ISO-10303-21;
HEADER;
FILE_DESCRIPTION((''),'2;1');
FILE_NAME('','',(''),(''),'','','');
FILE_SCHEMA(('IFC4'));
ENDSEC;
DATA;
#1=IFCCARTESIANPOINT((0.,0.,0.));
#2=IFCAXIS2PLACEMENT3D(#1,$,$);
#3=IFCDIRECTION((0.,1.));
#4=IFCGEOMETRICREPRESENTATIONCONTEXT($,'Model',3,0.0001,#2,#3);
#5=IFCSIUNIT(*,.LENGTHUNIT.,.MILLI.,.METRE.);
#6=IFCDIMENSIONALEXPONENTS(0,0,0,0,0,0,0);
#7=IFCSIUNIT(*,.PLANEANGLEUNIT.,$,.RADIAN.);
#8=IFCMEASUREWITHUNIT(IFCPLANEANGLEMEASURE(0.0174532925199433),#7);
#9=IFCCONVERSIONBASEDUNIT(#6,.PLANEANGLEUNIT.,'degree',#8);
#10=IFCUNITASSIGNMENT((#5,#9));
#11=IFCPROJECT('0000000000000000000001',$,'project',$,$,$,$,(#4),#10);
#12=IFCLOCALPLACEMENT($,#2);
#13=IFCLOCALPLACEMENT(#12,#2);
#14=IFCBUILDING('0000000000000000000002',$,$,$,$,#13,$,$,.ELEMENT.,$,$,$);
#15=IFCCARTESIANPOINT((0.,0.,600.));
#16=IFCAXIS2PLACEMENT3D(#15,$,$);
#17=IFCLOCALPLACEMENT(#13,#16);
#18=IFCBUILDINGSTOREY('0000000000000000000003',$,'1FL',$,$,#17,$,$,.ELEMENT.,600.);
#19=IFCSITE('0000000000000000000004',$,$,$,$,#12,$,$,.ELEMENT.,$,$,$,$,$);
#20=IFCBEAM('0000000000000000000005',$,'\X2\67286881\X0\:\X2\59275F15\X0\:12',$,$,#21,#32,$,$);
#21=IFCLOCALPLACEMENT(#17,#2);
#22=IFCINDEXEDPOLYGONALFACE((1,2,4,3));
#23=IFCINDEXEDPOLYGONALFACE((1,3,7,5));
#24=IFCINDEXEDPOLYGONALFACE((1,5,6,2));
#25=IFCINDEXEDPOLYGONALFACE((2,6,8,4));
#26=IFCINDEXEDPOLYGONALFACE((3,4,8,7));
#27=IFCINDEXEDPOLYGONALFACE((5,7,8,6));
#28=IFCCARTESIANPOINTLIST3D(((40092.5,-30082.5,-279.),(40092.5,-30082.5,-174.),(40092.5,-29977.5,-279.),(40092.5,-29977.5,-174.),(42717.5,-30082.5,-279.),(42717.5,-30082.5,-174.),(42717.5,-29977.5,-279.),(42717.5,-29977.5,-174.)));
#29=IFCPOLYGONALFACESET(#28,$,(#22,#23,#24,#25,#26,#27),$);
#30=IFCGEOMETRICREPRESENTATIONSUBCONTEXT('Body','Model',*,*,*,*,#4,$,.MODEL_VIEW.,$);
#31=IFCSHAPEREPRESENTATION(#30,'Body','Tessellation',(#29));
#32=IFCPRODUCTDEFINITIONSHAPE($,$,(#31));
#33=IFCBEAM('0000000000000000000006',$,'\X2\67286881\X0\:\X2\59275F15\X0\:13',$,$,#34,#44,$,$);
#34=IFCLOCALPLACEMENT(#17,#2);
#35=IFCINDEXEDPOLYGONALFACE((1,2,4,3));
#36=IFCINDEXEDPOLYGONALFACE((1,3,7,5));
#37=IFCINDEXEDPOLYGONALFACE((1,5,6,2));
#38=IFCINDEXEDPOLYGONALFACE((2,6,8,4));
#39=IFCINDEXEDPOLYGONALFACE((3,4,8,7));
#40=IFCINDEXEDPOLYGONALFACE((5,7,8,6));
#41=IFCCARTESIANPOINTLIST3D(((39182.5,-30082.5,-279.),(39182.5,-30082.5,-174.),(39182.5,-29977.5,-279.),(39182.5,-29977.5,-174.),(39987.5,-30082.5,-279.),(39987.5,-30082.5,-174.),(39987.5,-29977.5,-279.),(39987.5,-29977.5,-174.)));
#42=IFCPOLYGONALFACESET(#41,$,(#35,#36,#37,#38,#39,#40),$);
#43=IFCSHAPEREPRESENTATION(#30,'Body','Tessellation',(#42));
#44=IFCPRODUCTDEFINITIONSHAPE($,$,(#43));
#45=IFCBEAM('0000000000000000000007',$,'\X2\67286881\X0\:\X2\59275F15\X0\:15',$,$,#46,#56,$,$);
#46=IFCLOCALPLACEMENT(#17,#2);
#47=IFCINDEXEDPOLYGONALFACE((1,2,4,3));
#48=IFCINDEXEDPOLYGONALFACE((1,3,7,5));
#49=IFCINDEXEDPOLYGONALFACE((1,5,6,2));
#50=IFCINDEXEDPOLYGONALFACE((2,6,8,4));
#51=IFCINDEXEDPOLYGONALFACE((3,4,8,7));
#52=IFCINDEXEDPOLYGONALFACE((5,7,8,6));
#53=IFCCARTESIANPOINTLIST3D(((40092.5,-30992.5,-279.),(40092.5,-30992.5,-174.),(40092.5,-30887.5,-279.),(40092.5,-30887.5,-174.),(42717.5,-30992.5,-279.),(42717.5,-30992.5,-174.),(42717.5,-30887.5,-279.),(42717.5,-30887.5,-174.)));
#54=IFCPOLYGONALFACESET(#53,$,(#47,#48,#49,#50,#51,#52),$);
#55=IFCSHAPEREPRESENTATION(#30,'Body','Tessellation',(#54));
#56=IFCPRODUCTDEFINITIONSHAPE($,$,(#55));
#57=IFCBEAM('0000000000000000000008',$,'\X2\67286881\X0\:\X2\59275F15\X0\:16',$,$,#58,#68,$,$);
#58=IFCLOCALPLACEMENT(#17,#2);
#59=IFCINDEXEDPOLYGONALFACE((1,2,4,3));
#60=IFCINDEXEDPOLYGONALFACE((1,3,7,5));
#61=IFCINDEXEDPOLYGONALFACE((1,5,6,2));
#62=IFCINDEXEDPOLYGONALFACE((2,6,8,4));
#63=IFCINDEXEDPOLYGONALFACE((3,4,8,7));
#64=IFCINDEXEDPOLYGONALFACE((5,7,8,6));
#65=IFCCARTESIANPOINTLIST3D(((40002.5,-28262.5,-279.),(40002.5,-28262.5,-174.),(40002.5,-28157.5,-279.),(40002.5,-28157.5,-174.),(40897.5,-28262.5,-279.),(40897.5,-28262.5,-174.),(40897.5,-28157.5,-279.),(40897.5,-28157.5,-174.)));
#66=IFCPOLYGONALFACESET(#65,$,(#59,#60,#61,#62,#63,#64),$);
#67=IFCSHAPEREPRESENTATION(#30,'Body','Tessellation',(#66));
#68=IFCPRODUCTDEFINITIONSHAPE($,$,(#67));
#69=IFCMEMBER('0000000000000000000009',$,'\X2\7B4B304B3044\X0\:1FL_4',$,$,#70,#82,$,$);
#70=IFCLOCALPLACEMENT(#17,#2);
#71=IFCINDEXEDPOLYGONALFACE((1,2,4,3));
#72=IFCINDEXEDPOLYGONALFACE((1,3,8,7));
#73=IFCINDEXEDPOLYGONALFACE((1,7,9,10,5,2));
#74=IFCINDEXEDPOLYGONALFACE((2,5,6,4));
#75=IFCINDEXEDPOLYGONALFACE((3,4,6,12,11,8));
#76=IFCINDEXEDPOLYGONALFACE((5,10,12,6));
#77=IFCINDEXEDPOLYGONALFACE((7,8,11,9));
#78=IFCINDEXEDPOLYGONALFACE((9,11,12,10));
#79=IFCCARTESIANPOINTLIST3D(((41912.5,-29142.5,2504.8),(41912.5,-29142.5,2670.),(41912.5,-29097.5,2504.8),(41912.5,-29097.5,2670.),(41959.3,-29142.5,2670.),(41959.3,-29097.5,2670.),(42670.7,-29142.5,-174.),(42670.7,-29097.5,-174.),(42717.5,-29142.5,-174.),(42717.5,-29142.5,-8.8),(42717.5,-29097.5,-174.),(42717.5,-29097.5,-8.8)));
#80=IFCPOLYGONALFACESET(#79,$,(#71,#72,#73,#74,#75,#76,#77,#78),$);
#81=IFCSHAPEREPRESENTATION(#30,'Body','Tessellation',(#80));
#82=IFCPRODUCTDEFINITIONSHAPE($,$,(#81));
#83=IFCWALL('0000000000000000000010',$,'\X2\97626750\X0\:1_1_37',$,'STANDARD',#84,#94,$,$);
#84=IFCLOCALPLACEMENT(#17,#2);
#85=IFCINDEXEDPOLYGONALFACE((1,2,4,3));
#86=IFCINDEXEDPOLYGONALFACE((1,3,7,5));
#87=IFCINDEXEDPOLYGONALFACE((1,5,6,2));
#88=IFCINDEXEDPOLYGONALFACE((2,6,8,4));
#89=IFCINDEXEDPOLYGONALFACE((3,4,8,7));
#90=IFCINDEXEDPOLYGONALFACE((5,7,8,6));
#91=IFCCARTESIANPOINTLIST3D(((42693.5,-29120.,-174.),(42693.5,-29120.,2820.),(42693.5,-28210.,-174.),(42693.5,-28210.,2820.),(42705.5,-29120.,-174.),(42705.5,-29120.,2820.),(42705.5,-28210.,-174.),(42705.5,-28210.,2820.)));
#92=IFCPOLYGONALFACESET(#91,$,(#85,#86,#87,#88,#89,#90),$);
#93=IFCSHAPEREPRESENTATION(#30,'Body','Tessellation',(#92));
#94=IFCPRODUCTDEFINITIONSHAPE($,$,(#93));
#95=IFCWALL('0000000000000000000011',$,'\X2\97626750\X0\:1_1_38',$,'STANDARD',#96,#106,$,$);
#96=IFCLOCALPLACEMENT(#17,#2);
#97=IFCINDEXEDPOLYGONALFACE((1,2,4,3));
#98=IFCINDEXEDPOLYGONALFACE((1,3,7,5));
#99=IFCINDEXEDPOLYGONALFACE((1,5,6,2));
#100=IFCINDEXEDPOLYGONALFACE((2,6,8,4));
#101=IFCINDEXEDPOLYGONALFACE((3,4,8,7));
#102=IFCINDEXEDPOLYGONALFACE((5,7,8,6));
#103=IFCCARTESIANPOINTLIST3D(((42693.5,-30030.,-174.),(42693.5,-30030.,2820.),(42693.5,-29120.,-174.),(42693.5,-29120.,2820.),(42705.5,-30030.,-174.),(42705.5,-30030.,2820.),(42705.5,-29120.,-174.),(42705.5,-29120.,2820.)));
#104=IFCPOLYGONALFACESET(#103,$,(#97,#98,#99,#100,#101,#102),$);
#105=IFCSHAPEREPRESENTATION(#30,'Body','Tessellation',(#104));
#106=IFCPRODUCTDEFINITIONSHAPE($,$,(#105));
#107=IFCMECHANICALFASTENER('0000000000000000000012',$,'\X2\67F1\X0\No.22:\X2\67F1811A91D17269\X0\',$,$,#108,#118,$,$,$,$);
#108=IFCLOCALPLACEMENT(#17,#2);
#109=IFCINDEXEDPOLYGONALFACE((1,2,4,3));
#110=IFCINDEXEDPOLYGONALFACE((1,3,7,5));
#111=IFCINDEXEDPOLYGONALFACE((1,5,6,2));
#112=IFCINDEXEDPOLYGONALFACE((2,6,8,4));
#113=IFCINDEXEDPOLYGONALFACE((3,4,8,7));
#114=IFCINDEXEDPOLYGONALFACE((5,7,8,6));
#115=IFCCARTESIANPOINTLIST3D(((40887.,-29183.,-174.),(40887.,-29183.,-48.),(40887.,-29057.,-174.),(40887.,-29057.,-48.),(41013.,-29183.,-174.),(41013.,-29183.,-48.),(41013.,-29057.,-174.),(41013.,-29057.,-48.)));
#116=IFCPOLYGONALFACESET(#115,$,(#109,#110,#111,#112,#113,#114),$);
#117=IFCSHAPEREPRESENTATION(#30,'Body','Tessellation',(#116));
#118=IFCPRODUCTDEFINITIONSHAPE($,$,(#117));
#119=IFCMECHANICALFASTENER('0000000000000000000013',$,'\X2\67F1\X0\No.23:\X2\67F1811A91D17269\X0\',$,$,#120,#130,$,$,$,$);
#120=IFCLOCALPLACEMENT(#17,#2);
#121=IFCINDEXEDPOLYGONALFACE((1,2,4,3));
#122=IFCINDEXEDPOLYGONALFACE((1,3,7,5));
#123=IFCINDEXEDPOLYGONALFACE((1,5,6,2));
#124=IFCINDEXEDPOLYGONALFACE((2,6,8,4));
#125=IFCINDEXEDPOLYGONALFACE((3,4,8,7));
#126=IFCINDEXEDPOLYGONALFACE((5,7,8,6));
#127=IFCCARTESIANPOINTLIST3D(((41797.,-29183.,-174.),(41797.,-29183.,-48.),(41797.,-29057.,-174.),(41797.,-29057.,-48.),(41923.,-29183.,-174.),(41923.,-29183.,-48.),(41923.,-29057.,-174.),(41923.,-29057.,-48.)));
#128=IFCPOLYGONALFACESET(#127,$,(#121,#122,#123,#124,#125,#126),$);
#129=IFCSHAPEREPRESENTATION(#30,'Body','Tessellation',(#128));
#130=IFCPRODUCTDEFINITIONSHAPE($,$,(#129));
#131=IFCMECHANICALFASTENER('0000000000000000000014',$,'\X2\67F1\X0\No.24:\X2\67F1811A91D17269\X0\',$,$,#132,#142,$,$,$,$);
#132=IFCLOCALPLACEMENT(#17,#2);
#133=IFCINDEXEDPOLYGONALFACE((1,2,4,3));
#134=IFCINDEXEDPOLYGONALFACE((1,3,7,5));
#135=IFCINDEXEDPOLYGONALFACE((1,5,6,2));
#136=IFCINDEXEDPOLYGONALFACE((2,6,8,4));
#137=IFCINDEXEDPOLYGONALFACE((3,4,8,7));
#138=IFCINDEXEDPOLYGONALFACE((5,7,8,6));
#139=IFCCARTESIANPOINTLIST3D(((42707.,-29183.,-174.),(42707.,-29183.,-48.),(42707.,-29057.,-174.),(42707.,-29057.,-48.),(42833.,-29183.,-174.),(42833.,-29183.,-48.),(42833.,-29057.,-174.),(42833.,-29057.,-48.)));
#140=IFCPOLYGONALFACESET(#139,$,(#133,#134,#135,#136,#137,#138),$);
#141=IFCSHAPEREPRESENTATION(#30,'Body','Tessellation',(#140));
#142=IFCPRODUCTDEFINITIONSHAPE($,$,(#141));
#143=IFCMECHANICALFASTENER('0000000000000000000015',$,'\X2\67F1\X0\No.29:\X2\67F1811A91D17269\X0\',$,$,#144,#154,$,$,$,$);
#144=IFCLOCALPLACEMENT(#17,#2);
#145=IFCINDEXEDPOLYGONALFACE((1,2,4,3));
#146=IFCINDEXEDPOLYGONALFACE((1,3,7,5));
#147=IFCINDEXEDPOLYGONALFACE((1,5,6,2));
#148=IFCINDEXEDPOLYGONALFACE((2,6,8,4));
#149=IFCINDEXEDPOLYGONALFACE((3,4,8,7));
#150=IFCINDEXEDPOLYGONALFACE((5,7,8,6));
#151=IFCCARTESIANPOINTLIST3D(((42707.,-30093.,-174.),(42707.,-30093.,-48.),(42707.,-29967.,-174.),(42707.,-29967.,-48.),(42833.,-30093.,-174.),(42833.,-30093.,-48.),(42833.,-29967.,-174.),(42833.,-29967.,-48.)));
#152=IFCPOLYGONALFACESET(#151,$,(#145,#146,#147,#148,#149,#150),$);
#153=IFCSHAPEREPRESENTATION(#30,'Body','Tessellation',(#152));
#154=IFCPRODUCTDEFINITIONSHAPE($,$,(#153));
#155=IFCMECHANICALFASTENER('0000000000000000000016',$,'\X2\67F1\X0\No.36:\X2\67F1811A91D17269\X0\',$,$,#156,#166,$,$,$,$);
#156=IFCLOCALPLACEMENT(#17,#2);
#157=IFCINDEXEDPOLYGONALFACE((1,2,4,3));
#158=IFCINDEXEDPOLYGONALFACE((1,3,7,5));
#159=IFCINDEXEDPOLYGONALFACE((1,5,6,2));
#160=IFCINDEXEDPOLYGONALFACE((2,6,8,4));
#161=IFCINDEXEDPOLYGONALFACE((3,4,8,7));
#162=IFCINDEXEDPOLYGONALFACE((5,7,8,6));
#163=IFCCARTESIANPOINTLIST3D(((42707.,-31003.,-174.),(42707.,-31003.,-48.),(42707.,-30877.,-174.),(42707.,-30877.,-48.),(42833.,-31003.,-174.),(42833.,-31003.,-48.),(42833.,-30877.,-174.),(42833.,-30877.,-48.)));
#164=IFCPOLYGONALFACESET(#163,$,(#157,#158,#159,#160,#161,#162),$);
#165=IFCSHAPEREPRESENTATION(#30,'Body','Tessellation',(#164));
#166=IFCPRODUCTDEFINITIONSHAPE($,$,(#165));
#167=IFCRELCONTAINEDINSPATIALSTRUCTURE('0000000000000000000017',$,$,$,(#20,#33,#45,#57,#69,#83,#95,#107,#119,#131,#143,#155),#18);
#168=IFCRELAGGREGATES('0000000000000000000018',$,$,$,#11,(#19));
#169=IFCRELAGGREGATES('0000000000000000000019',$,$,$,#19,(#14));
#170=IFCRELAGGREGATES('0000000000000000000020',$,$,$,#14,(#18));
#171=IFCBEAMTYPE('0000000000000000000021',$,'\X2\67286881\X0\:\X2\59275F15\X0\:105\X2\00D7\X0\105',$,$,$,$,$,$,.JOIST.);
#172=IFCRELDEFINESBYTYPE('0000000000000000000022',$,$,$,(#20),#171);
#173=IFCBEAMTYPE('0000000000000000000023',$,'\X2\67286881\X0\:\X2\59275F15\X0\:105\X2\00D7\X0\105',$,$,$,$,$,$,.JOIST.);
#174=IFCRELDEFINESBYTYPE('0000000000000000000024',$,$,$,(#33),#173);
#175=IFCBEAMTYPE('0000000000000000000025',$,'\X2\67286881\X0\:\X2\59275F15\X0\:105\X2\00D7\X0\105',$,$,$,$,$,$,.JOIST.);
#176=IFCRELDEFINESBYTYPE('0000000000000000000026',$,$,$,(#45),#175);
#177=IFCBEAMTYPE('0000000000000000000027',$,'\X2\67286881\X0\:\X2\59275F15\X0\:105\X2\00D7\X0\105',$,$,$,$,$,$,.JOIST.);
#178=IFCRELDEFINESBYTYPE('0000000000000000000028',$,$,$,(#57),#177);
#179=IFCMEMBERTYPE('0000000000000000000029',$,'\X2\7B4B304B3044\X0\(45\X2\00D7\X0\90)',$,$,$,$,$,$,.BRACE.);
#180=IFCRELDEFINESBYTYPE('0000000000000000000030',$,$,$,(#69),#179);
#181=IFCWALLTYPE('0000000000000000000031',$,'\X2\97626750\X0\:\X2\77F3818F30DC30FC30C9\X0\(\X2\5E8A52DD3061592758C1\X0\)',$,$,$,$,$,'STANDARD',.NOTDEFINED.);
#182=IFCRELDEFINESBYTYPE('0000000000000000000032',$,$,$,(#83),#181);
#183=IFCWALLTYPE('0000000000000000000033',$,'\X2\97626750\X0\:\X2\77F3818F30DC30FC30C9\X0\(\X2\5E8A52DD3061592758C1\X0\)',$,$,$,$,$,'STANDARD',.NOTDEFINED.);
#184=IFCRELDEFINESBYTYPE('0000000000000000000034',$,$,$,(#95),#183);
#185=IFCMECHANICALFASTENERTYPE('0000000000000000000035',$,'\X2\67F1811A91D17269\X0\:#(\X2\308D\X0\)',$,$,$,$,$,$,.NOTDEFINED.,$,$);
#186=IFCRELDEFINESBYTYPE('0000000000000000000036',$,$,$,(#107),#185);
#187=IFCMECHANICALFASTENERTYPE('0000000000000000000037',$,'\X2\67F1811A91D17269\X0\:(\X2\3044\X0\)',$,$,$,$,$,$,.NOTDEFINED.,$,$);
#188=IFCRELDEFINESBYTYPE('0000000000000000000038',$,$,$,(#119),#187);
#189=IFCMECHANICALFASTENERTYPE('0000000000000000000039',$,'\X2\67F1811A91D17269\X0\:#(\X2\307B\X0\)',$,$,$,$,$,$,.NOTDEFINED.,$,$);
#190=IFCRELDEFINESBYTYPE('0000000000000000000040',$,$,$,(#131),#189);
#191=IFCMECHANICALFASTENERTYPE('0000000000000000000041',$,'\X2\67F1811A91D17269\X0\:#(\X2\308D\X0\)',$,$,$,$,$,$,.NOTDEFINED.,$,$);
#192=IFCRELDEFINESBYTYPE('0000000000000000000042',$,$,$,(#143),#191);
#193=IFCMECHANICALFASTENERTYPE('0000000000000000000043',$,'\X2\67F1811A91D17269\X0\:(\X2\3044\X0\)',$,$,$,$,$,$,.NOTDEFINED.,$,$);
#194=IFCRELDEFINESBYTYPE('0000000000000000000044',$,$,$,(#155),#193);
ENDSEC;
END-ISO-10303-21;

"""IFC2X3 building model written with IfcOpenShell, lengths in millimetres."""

from ifc_helpers import new_model, entity, si_unit, converted_unit, direction, frame, origin, origin_with_axes, origin_2d, place, context, subcontext, project, spatial, polyline, rectangle, outline, extrude, type_object, element, save


model = new_model("IFC2X3")

# Units and contexts
model_context = context("Model", 3, precision=0.0001, world=origin(), true_north=direction((0.0, 1.0)))
body_context = subcontext(model_context, "Body", "Model", "MODEL_VIEW")
ifc_project = project(units=[si_unit("LENGTHUNIT", "METRE", prefix="MILLI"), converted_unit("PLANEANGLEUNIT", "degree", entity("IfcPlaneAngleMeasure", 0.0174532925199433), si_unit("PLANEANGLEUNIT", "RADIAN"), dimensions=[0, 0, 0, 0, 0, 0, 0])], contexts=[model_context])

# Site, building, storey
site_placement = place(None, origin())
site = spatial("IfcSite", under=ifc_project, at=site_placement, CompositionType="ELEMENT")
building_placement = place(site_placement, origin())
building = spatial("IfcBuilding", under=site, at=building_placement, CompositionType="ELEMENT")
storey_placement = place(building_placement, frame((0.0, 0.0, 600.0)))
storey = spatial("IfcBuildingStorey", under=building, at=storey_placement, Name="1FL", CompositionType="ELEMENT", Elevation=600.0)

# Beams
beam_type_1 = type_object("IfcBeamType", Name="木梁:大引:105×105", PredefinedType="JOIST")
beam_1_placement = place(storey_placement, frame((40092.5, -30030.0, -226.5), z_axis=(1.0, 0.0, 0.0), x_axis=(0.0, 1.0, 0.0)))
element("IfcBeam", 1, at=beam_1_placement, inside=storey, type_object=beam_type_1, Name="木梁:大引:12", context=body_context, shape_type="SweptSolid", body=[
    extrude(rectangle(XDim=105.0, YDim=105.0, at=origin_2d()), origin_with_axes(), (0.0, 0.0, 1.0), 2625.0),
])
beam_type_2 = type_object("IfcBeamType", Name="木梁:大引:105×105", PredefinedType="JOIST")
beam_2_placement = place(storey_placement, frame((39182.5, -30030.0, -226.5), z_axis=(1.0, 0.0, 0.0), x_axis=(0.0, 1.0, 0.0)))
element("IfcBeam", 2, at=beam_2_placement, inside=storey, type_object=beam_type_2, Name="木梁:大引:13", context=body_context, shape_type="SweptSolid", body=[
    extrude(rectangle(XDim=105.0, YDim=105.0, at=origin_2d()), origin_with_axes(), (0.0, 0.0, 1.0), 805.0),
])
beam_type_3 = type_object("IfcBeamType", Name="木梁:大引:105×105", PredefinedType="JOIST")
beam_3_placement = place(storey_placement, frame((40092.5, -30940.0, -226.5), z_axis=(1.0, 0.0, 0.0), x_axis=(0.0, 1.0, 0.0)))
element("IfcBeam", 3, at=beam_3_placement, inside=storey, type_object=beam_type_3, Name="木梁:大引:15", context=body_context, shape_type="SweptSolid", body=[
    extrude(rectangle(XDim=105.0, YDim=105.0, at=origin_2d()), origin_with_axes(), (0.0, 0.0, 1.0), 2625.0),
])
beam_type_4 = type_object("IfcBeamType", Name="木梁:大引:105×105", PredefinedType="JOIST")
beam_4_placement = place(storey_placement, frame((40002.5, -28210.0, -226.5), z_axis=(1.0, 0.0, 0.0), x_axis=(0.0, 1.0, 0.0)))
element("IfcBeam", 4, at=beam_4_placement, inside=storey, type_object=beam_type_4, Name="木梁:大引:16", context=body_context, shape_type="SweptSolid", body=[
    extrude(rectangle(XDim=105.0, YDim=105.0, at=origin_2d()), origin_with_axes(), (0.0, 0.0, 1.0), 895.0),
])

# Member
member_type_1 = type_object("IfcMemberType", Name="筋かい(45×90)", PredefinedType="BRACE")
member_1_placement = place(storey_placement, frame((42717.5, -29120.0, -174.0), z_axis=(-0.272352, 0.0, 0.962198), x_axis=(0.962198, 0.0, 0.272352)))
element("IfcMember", 5, at=member_1_placement, inside=storey, type_object=member_type_1, Name="筋かい:1FL_4", context=body_context, shape_type="SweptSolid", body=[
    extrude(outline(polyline([(0.0, 0.0), (12.7, -45.0), (2796.8, -45.0), (2955.7, 0.0), (2943.0, 45.0), (159.0, 45.0), (0.0, 0.0)])), frame((0.0, -22.5, 0.0), z_axis=(0.0, 1.0, 0.0), x_axis=(0.0, 0.0, 1.0)), (0.0, 0.0, 1.0), 45.0),
])

# Walls
wall_type_1 = type_object("IfcWallType", Name="面材:石膏ボード(床勝ち大壁)", ElementType="STANDARD", PredefinedType="NOTDEFINED")
wall_1_placement = place(storey_placement, frame((42705.5, -28665.0, -174.0), z_axis=(-1.0, 0.0, 0.0), x_axis=(0.0, -1.0, 0.0)))
element("IfcWall", 6, at=wall_1_placement, inside=storey, type_object=wall_type_1, Name="面材:1_1_37", ObjectType="STANDARD", context=body_context, shape_type="SweptSolid", body=[
    extrude(outline(polyline([(455.0, 0.0, 0.0), (-455.0, 0.0, 0.0), (-455.0, 2994.0, 0.0), (455.0, 2994.0, 0.0), (455.0, 0.0, 0.0)])), origin_with_axes(), (0.0, 0.0, 1.0), 12.0),
])
wall_type_2 = type_object("IfcWallType", Name="面材:石膏ボード(床勝ち大壁)", ElementType="STANDARD", PredefinedType="NOTDEFINED")
wall_2_placement = place(storey_placement, frame((42705.5, -29575.0, -174.0), z_axis=(-1.0, 0.0, 0.0), x_axis=(0.0, -1.0, 0.0)))
element("IfcWall", 7, at=wall_2_placement, inside=storey, type_object=wall_type_2, Name="面材:1_1_38", ObjectType="STANDARD", context=body_context, shape_type="SweptSolid", body=[
    extrude(outline(polyline([(455.0, 0.0, 0.0), (-455.0, 0.0, 0.0), (-455.0, 2994.0, 0.0), (455.0, 2994.0, 0.0), (455.0, 0.0, 0.0)])), origin_with_axes(), (0.0, 0.0, 1.0), 12.0),
])

# Mechanical fasteners
mechanical_fastener_type_1 = type_object("IfcMechanicalFastenerType", Name="柱脚金物:#(ろ)")
mechanical_fastener_1_placement = place(storey_placement, frame((40950.0, -29120.0, -174.0)))
element("IfcMechanicalFastener", 8, at=mechanical_fastener_1_placement, inside=storey, type_object=mechanical_fastener_type_1, Name="柱No.22:柱脚金物", context=body_context, shape_type="SweptSolid", body=[
    extrude(rectangle(XDim=126.0, YDim=126.0, at=origin_2d()), origin_with_axes(), (0.0, 0.0, 1.0), 126.0),
])
mechanical_fastener_type_2 = type_object("IfcMechanicalFastenerType", Name="柱脚金物:(い)")
mechanical_fastener_2_placement = place(storey_placement, frame((41860.0, -29120.0, -174.0)))
element("IfcMechanicalFastener", 9, at=mechanical_fastener_2_placement, inside=storey, type_object=mechanical_fastener_type_2, Name="柱No.23:柱脚金物", context=body_context, shape_type="SweptSolid", body=[
    extrude(rectangle(XDim=126.0, YDim=126.0, at=origin_2d()), origin_with_axes(), (0.0, 0.0, 1.0), 126.0),
])
mechanical_fastener_type_3 = type_object("IfcMechanicalFastenerType", Name="柱脚金物:#(ほ)")
mechanical_fastener_3_placement = place(storey_placement, frame((42770.0, -29120.0, -174.0)))
element("IfcMechanicalFastener", 10, at=mechanical_fastener_3_placement, inside=storey, type_object=mechanical_fastener_type_3, Name="柱No.24:柱脚金物", context=body_context, shape_type="SweptSolid", body=[
    extrude(rectangle(XDim=126.0, YDim=126.0, at=origin_2d()), origin_with_axes(), (0.0, 0.0, 1.0), 126.0),
])
mechanical_fastener_type_4 = type_object("IfcMechanicalFastenerType", Name="柱脚金物:#(ろ)")
mechanical_fastener_4_placement = place(storey_placement, frame((42770.0, -30030.0, -174.0)))
element("IfcMechanicalFastener", 11, at=mechanical_fastener_4_placement, inside=storey, type_object=mechanical_fastener_type_4, Name="柱No.29:柱脚金物", context=body_context, shape_type="SweptSolid", body=[
    extrude(rectangle(XDim=126.0, YDim=126.0, at=origin_2d()), origin_with_axes(), (0.0, 0.0, 1.0), 126.0),
])
mechanical_fastener_type_5 = type_object("IfcMechanicalFastenerType", Name="柱脚金物:(い)")
mechanical_fastener_5_placement = place(storey_placement, frame((42770.0, -30940.0, -174.0)))
element("IfcMechanicalFastener", 12, at=mechanical_fastener_5_placement, inside=storey, type_object=mechanical_fastener_type_5, Name="柱No.36:柱脚金物", context=body_context, shape_type="SweptSolid", body=[
    extrude(rectangle(XDim=126.0, YDim=126.0, at=origin_2d()), origin_with_axes(), (0.0, 0.0, 1.0), 126.0),
])

save(model, "model.ifc")
